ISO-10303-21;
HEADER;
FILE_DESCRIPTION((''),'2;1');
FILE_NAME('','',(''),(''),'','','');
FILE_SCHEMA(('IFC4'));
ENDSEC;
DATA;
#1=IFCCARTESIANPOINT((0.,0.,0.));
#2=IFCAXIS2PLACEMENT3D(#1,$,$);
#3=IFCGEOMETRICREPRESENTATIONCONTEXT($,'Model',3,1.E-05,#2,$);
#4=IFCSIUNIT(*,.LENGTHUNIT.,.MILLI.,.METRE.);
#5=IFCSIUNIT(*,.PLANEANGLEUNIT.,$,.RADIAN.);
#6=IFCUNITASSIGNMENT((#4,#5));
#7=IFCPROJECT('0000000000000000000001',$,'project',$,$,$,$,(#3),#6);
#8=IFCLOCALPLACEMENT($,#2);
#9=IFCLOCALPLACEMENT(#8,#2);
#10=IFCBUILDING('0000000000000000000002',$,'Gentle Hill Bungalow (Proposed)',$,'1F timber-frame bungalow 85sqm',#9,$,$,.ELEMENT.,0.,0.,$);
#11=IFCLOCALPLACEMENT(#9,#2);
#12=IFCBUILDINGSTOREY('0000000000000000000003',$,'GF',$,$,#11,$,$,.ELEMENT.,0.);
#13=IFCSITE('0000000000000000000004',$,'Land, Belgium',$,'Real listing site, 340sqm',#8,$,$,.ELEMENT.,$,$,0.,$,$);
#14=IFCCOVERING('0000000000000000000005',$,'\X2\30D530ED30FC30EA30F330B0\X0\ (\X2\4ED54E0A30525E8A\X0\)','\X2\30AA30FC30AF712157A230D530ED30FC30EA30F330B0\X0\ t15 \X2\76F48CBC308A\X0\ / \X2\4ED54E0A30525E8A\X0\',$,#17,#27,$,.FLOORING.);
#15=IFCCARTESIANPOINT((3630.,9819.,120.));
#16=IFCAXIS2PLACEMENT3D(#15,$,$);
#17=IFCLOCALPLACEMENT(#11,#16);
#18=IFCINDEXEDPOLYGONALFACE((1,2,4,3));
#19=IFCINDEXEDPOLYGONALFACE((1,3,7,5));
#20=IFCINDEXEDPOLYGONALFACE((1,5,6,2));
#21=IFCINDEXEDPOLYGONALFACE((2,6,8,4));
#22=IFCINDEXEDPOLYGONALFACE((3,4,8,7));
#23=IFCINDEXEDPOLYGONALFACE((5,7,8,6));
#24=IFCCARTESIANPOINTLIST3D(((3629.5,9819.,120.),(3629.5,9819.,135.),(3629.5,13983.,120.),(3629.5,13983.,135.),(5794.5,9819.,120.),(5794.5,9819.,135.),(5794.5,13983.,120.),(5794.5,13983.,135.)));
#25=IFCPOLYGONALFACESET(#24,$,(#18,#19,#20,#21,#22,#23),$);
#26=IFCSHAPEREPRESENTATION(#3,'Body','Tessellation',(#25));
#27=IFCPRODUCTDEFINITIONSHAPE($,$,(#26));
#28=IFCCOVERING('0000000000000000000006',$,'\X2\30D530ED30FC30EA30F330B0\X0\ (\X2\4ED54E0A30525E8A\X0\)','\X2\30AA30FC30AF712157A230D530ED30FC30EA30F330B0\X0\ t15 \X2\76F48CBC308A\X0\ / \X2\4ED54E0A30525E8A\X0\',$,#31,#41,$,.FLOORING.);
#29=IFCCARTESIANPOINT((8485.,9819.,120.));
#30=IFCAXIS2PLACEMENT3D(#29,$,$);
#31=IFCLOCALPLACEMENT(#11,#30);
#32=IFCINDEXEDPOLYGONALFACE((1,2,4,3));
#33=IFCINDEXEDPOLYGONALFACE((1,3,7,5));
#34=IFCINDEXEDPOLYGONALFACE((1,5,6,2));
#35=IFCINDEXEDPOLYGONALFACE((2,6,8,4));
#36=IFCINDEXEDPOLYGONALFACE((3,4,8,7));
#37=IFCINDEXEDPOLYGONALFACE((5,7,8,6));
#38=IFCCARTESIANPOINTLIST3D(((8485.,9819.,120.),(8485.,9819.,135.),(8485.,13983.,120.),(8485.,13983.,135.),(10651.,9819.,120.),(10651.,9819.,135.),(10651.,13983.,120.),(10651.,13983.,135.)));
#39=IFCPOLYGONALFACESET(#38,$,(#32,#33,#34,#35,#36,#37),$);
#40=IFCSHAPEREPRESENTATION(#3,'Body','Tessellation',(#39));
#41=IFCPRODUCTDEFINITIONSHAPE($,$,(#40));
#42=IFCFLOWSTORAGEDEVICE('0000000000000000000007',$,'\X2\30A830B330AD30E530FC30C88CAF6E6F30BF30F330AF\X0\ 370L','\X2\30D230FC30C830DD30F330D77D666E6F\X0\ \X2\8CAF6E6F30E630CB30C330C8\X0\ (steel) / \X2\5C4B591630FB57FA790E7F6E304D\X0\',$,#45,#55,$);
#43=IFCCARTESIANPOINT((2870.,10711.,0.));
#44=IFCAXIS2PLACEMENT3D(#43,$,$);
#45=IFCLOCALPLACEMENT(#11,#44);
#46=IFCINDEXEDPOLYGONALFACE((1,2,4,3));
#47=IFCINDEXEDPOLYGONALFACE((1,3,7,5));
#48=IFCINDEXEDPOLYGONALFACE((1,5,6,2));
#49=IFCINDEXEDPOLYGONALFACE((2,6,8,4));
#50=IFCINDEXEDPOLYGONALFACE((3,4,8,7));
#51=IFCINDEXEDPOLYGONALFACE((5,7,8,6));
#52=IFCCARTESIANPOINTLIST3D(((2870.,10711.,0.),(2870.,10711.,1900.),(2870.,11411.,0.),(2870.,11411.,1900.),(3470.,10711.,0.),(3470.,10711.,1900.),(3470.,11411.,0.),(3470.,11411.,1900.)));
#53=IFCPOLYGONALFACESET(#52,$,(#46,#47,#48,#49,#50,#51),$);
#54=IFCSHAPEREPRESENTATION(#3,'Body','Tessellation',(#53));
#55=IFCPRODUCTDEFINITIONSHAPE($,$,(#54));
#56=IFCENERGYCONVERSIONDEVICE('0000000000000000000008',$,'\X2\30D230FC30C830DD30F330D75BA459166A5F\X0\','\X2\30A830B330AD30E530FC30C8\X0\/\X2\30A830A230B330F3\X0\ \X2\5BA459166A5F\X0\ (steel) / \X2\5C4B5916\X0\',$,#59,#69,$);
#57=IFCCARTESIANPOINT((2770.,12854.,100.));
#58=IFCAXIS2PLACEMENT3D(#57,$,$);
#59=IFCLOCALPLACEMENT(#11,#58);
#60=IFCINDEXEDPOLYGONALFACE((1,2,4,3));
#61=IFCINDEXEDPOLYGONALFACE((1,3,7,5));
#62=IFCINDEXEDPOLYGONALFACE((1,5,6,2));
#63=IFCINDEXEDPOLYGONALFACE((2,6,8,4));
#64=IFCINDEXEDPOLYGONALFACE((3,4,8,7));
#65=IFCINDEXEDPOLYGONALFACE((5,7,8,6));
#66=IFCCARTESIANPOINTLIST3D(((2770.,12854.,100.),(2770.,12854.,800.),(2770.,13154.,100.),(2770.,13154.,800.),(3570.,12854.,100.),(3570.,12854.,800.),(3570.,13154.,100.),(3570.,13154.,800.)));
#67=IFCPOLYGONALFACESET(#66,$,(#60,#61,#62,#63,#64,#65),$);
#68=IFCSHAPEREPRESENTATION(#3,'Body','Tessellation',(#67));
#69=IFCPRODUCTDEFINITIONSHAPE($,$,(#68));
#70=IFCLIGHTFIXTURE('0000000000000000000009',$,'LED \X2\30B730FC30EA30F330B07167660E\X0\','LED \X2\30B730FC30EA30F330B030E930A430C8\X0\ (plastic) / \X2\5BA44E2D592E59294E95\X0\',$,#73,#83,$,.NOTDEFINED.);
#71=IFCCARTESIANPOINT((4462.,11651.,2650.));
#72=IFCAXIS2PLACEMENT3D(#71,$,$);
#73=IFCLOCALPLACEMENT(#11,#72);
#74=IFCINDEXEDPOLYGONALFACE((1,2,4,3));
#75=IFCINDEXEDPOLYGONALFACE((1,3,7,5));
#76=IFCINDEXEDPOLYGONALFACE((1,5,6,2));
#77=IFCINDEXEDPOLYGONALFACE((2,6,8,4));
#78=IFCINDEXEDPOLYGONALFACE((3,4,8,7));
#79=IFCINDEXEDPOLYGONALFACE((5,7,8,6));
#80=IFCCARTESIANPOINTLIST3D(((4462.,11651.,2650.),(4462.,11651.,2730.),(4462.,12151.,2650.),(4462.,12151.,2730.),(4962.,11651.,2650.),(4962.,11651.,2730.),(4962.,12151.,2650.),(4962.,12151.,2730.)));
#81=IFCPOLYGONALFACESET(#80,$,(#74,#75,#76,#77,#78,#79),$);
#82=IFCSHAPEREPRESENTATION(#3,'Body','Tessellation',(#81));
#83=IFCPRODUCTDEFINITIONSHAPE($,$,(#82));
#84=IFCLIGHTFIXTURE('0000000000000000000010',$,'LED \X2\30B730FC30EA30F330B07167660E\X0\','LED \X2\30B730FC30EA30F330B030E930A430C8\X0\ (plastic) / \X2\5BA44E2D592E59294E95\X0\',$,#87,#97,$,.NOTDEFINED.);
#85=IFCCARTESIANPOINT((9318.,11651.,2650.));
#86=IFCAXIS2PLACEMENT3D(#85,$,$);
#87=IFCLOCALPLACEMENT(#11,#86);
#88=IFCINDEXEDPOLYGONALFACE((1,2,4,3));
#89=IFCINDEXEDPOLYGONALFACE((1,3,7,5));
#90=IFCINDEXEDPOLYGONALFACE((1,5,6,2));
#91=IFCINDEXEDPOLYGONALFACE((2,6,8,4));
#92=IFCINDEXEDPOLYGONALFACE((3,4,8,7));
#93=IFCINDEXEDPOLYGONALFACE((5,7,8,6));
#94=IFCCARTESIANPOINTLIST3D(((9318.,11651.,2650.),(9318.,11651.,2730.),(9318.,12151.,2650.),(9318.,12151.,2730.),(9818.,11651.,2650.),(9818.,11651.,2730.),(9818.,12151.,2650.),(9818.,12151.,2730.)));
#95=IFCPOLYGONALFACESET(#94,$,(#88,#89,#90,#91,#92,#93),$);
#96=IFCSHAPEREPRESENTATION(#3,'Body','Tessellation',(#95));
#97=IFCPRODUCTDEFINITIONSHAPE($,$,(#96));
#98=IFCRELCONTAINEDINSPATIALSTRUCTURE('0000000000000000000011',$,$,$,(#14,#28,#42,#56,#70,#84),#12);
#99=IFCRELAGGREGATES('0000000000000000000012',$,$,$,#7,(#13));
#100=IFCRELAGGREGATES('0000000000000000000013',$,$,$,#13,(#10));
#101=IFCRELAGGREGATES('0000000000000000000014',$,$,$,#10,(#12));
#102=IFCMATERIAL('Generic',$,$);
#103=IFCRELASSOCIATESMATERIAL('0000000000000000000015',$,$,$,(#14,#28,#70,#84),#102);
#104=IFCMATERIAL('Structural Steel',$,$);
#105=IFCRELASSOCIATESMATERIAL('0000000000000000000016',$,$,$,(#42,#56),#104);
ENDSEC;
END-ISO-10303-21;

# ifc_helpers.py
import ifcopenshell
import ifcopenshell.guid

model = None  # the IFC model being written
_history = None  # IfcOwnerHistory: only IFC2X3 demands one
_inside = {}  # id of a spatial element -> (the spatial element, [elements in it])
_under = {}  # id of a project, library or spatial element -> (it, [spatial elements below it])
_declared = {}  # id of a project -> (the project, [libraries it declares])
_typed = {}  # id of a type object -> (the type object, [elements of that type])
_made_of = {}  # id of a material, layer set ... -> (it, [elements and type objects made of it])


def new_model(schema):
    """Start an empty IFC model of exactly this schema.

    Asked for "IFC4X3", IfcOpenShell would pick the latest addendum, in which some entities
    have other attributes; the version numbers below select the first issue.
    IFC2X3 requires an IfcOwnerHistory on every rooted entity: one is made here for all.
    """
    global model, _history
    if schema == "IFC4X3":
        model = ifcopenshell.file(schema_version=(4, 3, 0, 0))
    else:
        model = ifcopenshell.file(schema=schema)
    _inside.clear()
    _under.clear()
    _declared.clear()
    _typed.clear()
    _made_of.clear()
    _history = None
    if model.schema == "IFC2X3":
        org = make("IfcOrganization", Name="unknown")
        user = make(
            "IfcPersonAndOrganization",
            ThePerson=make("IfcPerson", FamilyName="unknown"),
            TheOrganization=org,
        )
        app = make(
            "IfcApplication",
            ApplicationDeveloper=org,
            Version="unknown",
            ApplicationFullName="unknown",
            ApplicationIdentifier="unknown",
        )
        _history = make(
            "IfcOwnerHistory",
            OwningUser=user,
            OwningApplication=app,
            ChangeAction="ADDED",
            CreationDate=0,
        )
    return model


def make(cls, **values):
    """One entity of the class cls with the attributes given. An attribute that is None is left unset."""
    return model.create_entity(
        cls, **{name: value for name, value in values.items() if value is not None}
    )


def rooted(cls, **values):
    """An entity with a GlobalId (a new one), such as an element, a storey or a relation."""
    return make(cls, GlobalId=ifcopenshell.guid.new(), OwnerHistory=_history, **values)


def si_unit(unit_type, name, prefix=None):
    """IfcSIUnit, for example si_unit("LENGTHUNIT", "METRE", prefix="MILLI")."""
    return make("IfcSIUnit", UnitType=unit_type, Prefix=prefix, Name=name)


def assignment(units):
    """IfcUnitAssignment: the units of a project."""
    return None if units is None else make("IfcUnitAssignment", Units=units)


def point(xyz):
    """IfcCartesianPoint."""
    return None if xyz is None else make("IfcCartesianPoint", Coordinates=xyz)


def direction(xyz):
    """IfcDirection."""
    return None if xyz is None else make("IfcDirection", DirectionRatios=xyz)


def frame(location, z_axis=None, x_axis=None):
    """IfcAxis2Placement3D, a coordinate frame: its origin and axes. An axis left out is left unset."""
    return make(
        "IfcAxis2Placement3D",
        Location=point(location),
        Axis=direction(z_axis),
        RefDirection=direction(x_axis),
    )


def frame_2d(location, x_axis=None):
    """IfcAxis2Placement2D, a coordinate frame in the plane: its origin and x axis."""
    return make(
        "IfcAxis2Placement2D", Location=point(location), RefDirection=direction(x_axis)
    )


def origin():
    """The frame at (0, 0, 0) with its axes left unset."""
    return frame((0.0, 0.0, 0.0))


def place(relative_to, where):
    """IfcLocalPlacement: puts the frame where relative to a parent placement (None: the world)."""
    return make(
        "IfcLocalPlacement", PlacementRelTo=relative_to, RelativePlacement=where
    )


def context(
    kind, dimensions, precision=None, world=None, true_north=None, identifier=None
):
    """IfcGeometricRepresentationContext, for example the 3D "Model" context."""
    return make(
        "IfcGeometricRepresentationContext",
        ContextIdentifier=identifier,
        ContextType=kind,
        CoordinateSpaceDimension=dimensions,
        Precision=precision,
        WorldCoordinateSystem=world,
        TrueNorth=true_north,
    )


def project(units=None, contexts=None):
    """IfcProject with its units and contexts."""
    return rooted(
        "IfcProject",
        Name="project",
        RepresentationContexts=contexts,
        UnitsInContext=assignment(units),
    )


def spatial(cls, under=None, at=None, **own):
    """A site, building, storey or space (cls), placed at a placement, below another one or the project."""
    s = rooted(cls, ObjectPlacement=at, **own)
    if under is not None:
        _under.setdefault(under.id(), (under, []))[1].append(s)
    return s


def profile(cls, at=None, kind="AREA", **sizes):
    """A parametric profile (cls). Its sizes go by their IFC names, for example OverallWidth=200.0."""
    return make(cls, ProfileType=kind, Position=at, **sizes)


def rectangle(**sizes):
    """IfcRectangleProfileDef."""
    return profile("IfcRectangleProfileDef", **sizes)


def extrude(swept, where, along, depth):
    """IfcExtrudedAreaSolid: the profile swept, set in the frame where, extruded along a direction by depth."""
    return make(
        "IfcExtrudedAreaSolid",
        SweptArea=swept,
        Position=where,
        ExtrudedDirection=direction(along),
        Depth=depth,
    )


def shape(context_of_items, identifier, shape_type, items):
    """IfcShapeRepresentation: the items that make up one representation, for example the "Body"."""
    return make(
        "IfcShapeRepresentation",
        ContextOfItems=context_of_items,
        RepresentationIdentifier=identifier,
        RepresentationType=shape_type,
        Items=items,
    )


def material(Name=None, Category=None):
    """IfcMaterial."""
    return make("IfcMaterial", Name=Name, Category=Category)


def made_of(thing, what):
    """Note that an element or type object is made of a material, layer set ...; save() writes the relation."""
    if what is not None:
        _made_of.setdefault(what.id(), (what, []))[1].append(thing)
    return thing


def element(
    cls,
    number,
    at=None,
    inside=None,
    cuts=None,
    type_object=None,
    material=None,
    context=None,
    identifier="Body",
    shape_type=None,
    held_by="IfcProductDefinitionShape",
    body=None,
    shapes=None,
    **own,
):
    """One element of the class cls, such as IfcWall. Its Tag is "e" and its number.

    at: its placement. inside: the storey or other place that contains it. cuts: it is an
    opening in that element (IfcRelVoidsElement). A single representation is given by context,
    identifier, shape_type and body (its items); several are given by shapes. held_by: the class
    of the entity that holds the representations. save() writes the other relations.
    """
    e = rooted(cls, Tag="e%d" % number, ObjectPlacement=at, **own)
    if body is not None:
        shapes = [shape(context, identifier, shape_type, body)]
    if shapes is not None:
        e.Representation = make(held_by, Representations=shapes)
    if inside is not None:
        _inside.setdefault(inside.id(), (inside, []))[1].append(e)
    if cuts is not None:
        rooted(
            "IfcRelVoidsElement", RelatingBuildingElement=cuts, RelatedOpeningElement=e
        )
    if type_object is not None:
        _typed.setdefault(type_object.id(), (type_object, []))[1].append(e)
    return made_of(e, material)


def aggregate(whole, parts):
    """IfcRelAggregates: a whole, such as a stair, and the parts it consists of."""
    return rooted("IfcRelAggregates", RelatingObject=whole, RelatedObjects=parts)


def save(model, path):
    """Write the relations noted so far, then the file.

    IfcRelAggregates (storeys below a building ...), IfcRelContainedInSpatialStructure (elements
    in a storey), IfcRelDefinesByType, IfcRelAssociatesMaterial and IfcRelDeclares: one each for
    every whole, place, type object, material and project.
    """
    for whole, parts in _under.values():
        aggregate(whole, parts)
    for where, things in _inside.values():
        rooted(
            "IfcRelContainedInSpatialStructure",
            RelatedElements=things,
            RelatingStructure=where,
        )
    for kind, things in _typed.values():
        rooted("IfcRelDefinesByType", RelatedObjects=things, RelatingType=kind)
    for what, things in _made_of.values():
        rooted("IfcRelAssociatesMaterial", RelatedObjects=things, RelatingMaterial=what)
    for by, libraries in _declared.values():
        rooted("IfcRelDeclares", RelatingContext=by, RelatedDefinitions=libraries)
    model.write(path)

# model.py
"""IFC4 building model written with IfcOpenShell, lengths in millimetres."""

from ifc_helpers import new_model, si_unit, frame, frame_2d, origin, place, context, project, spatial, rectangle, extrude, material, element, save


model = new_model("IFC4")

# Units and contexts
model_context = context("Model", 3, precision=1e-05, world=origin())
ifc_project = project(units=[si_unit("LENGTHUNIT", "METRE", prefix="MILLI"), si_unit("PLANEANGLEUNIT", "RADIAN")], contexts=[model_context])

# Site, building, storey
site_placement = place(None, origin())
site = spatial("IfcSite", under=ifc_project, at=site_placement, Name="Land, Belgium", ObjectType="Real listing site, 340sqm", CompositionType="ELEMENT", RefElevation=0.0)
building_placement = place(site_placement, origin())
building = spatial("IfcBuilding", under=site, at=building_placement, Name="Gentle Hill Bungalow (Proposed)", ObjectType="1F timber-frame bungalow 85sqm", CompositionType="ELEMENT", ElevationOfRefHeight=0.0, ElevationOfTerrain=0.0)
storey_placement = place(building_placement, origin())
storey = spatial("IfcBuildingStorey", under=building, at=storey_placement, Name="GF", CompositionType="ELEMENT", Elevation=0.0)

# Shared definitions
ifc_material_1 = material(Name="Structural Steel")

# Coverings
ifc_material_2 = material(Name="Generic")
covering_1_placement = place(storey_placement, frame((3630.0, 9819.0, 120.0)))
element("IfcCovering", 1, at=covering_1_placement, inside=storey, material=ifc_material_2, Name="フローリング (仕上げ床)", Description="オーク無垢フローリング t15 直貼り / 仕上げ床", PredefinedType="FLOORING", context=model_context, shape_type="SweptSolid", body=[
    extrude(rectangle(XDim=2165.0, YDim=4164.0, at=frame_2d((1082.0, 2082.0))), frame((3630.0, 9819.0, 120.0)), (0.0, 0.0, 1.0), 15.0),
])
covering_2_placement = place(storey_placement, frame((8485.0, 9819.0, 120.0)))
element("IfcCovering", 2, at=covering_2_placement, inside=storey, material=ifc_material_2, Name="フローリング (仕上げ床)", Description="オーク無垢フローリング t15 直貼り / 仕上げ床", PredefinedType="FLOORING", context=model_context, shape_type="SweptSolid", body=[
    extrude(rectangle(XDim=2166.0, YDim=4164.0, at=frame_2d((1083.0, 2082.0))), frame((8485.0, 9819.0, 120.0)), (0.0, 0.0, 1.0), 15.0),
])

# Flow storage device
flow_storage_device_placement = place(storey_placement, frame((2870.0, 10711.0, 0.0)))
element("IfcFlowStorageDevice", 3, at=flow_storage_device_placement, inside=storey, material=ifc_material_1, Name="エコキュート貯湯タンク 370L", Description="ヒートポンプ給湯 貯湯ユニット (steel) / 屋外・基礎置き", context=model_context, shape_type="SweptSolid", body=[
    extrude(rectangle(XDim=600.0, YDim=700.0, at=frame_2d((300.0, 350.0))), frame((2870.0, 10711.0, 0.0)), (0.0, 0.0, 1.0), 1900.0),
])

# Energy conversion device
energy_conversion_device_placement = place(storey_placement, frame((2770.0, 12854.0, 100.0)))
element("IfcEnergyConversionDevice", 4, at=energy_conversion_device_placement, inside=storey, material=ifc_material_1, Name="ヒートポンプ室外機", Description="エコキュート/エアコン 室外機 (steel) / 屋外", context=model_context, shape_type="SweptSolid", body=[
    extrude(rectangle(XDim=800.0, YDim=300.0, at=frame_2d((400.0, 150.0))), frame((2770.0, 12854.0, 100.0)), (0.0, 0.0, 1.0), 700.0),
])

# Light fixtures
light_fixture_1_placement = place(storey_placement, frame((4462.0, 11651.0, 2650.0)))
element("IfcLightFixture", 5, at=light_fixture_1_placement, inside=storey, material=ifc_material_2, Name="LED シーリング照明", Description="LED シーリングライト (plastic) / 室中央天井", PredefinedType="NOTDEFINED", context=model_context, shape_type="SweptSolid", body=[
    extrude(rectangle(XDim=500.0, YDim=500.0, at=frame_2d((250.0, 250.0))), frame((4462.0, 11651.0, 2650.0)), (0.0, 0.0, 1.0), 80.0),
])
light_fixture_2_placement = place(storey_placement, frame((9318.0, 11651.0, 2650.0)))
element("IfcLightFixture", 6, at=light_fixture_2_placement, inside=storey, material=ifc_material_2, Name="LED シーリング照明", Description="LED シーリングライト (plastic) / 室中央天井", PredefinedType="NOTDEFINED", context=model_context, shape_type="SweptSolid", body=[
    extrude(rectangle(XDim=500.0, YDim=500.0, at=frame_2d((250.0, 250.0))), frame((9318.0, 11651.0, 2650.0)), (0.0, 0.0, 1.0), 80.0),
])

save(model, "model.ifc")
